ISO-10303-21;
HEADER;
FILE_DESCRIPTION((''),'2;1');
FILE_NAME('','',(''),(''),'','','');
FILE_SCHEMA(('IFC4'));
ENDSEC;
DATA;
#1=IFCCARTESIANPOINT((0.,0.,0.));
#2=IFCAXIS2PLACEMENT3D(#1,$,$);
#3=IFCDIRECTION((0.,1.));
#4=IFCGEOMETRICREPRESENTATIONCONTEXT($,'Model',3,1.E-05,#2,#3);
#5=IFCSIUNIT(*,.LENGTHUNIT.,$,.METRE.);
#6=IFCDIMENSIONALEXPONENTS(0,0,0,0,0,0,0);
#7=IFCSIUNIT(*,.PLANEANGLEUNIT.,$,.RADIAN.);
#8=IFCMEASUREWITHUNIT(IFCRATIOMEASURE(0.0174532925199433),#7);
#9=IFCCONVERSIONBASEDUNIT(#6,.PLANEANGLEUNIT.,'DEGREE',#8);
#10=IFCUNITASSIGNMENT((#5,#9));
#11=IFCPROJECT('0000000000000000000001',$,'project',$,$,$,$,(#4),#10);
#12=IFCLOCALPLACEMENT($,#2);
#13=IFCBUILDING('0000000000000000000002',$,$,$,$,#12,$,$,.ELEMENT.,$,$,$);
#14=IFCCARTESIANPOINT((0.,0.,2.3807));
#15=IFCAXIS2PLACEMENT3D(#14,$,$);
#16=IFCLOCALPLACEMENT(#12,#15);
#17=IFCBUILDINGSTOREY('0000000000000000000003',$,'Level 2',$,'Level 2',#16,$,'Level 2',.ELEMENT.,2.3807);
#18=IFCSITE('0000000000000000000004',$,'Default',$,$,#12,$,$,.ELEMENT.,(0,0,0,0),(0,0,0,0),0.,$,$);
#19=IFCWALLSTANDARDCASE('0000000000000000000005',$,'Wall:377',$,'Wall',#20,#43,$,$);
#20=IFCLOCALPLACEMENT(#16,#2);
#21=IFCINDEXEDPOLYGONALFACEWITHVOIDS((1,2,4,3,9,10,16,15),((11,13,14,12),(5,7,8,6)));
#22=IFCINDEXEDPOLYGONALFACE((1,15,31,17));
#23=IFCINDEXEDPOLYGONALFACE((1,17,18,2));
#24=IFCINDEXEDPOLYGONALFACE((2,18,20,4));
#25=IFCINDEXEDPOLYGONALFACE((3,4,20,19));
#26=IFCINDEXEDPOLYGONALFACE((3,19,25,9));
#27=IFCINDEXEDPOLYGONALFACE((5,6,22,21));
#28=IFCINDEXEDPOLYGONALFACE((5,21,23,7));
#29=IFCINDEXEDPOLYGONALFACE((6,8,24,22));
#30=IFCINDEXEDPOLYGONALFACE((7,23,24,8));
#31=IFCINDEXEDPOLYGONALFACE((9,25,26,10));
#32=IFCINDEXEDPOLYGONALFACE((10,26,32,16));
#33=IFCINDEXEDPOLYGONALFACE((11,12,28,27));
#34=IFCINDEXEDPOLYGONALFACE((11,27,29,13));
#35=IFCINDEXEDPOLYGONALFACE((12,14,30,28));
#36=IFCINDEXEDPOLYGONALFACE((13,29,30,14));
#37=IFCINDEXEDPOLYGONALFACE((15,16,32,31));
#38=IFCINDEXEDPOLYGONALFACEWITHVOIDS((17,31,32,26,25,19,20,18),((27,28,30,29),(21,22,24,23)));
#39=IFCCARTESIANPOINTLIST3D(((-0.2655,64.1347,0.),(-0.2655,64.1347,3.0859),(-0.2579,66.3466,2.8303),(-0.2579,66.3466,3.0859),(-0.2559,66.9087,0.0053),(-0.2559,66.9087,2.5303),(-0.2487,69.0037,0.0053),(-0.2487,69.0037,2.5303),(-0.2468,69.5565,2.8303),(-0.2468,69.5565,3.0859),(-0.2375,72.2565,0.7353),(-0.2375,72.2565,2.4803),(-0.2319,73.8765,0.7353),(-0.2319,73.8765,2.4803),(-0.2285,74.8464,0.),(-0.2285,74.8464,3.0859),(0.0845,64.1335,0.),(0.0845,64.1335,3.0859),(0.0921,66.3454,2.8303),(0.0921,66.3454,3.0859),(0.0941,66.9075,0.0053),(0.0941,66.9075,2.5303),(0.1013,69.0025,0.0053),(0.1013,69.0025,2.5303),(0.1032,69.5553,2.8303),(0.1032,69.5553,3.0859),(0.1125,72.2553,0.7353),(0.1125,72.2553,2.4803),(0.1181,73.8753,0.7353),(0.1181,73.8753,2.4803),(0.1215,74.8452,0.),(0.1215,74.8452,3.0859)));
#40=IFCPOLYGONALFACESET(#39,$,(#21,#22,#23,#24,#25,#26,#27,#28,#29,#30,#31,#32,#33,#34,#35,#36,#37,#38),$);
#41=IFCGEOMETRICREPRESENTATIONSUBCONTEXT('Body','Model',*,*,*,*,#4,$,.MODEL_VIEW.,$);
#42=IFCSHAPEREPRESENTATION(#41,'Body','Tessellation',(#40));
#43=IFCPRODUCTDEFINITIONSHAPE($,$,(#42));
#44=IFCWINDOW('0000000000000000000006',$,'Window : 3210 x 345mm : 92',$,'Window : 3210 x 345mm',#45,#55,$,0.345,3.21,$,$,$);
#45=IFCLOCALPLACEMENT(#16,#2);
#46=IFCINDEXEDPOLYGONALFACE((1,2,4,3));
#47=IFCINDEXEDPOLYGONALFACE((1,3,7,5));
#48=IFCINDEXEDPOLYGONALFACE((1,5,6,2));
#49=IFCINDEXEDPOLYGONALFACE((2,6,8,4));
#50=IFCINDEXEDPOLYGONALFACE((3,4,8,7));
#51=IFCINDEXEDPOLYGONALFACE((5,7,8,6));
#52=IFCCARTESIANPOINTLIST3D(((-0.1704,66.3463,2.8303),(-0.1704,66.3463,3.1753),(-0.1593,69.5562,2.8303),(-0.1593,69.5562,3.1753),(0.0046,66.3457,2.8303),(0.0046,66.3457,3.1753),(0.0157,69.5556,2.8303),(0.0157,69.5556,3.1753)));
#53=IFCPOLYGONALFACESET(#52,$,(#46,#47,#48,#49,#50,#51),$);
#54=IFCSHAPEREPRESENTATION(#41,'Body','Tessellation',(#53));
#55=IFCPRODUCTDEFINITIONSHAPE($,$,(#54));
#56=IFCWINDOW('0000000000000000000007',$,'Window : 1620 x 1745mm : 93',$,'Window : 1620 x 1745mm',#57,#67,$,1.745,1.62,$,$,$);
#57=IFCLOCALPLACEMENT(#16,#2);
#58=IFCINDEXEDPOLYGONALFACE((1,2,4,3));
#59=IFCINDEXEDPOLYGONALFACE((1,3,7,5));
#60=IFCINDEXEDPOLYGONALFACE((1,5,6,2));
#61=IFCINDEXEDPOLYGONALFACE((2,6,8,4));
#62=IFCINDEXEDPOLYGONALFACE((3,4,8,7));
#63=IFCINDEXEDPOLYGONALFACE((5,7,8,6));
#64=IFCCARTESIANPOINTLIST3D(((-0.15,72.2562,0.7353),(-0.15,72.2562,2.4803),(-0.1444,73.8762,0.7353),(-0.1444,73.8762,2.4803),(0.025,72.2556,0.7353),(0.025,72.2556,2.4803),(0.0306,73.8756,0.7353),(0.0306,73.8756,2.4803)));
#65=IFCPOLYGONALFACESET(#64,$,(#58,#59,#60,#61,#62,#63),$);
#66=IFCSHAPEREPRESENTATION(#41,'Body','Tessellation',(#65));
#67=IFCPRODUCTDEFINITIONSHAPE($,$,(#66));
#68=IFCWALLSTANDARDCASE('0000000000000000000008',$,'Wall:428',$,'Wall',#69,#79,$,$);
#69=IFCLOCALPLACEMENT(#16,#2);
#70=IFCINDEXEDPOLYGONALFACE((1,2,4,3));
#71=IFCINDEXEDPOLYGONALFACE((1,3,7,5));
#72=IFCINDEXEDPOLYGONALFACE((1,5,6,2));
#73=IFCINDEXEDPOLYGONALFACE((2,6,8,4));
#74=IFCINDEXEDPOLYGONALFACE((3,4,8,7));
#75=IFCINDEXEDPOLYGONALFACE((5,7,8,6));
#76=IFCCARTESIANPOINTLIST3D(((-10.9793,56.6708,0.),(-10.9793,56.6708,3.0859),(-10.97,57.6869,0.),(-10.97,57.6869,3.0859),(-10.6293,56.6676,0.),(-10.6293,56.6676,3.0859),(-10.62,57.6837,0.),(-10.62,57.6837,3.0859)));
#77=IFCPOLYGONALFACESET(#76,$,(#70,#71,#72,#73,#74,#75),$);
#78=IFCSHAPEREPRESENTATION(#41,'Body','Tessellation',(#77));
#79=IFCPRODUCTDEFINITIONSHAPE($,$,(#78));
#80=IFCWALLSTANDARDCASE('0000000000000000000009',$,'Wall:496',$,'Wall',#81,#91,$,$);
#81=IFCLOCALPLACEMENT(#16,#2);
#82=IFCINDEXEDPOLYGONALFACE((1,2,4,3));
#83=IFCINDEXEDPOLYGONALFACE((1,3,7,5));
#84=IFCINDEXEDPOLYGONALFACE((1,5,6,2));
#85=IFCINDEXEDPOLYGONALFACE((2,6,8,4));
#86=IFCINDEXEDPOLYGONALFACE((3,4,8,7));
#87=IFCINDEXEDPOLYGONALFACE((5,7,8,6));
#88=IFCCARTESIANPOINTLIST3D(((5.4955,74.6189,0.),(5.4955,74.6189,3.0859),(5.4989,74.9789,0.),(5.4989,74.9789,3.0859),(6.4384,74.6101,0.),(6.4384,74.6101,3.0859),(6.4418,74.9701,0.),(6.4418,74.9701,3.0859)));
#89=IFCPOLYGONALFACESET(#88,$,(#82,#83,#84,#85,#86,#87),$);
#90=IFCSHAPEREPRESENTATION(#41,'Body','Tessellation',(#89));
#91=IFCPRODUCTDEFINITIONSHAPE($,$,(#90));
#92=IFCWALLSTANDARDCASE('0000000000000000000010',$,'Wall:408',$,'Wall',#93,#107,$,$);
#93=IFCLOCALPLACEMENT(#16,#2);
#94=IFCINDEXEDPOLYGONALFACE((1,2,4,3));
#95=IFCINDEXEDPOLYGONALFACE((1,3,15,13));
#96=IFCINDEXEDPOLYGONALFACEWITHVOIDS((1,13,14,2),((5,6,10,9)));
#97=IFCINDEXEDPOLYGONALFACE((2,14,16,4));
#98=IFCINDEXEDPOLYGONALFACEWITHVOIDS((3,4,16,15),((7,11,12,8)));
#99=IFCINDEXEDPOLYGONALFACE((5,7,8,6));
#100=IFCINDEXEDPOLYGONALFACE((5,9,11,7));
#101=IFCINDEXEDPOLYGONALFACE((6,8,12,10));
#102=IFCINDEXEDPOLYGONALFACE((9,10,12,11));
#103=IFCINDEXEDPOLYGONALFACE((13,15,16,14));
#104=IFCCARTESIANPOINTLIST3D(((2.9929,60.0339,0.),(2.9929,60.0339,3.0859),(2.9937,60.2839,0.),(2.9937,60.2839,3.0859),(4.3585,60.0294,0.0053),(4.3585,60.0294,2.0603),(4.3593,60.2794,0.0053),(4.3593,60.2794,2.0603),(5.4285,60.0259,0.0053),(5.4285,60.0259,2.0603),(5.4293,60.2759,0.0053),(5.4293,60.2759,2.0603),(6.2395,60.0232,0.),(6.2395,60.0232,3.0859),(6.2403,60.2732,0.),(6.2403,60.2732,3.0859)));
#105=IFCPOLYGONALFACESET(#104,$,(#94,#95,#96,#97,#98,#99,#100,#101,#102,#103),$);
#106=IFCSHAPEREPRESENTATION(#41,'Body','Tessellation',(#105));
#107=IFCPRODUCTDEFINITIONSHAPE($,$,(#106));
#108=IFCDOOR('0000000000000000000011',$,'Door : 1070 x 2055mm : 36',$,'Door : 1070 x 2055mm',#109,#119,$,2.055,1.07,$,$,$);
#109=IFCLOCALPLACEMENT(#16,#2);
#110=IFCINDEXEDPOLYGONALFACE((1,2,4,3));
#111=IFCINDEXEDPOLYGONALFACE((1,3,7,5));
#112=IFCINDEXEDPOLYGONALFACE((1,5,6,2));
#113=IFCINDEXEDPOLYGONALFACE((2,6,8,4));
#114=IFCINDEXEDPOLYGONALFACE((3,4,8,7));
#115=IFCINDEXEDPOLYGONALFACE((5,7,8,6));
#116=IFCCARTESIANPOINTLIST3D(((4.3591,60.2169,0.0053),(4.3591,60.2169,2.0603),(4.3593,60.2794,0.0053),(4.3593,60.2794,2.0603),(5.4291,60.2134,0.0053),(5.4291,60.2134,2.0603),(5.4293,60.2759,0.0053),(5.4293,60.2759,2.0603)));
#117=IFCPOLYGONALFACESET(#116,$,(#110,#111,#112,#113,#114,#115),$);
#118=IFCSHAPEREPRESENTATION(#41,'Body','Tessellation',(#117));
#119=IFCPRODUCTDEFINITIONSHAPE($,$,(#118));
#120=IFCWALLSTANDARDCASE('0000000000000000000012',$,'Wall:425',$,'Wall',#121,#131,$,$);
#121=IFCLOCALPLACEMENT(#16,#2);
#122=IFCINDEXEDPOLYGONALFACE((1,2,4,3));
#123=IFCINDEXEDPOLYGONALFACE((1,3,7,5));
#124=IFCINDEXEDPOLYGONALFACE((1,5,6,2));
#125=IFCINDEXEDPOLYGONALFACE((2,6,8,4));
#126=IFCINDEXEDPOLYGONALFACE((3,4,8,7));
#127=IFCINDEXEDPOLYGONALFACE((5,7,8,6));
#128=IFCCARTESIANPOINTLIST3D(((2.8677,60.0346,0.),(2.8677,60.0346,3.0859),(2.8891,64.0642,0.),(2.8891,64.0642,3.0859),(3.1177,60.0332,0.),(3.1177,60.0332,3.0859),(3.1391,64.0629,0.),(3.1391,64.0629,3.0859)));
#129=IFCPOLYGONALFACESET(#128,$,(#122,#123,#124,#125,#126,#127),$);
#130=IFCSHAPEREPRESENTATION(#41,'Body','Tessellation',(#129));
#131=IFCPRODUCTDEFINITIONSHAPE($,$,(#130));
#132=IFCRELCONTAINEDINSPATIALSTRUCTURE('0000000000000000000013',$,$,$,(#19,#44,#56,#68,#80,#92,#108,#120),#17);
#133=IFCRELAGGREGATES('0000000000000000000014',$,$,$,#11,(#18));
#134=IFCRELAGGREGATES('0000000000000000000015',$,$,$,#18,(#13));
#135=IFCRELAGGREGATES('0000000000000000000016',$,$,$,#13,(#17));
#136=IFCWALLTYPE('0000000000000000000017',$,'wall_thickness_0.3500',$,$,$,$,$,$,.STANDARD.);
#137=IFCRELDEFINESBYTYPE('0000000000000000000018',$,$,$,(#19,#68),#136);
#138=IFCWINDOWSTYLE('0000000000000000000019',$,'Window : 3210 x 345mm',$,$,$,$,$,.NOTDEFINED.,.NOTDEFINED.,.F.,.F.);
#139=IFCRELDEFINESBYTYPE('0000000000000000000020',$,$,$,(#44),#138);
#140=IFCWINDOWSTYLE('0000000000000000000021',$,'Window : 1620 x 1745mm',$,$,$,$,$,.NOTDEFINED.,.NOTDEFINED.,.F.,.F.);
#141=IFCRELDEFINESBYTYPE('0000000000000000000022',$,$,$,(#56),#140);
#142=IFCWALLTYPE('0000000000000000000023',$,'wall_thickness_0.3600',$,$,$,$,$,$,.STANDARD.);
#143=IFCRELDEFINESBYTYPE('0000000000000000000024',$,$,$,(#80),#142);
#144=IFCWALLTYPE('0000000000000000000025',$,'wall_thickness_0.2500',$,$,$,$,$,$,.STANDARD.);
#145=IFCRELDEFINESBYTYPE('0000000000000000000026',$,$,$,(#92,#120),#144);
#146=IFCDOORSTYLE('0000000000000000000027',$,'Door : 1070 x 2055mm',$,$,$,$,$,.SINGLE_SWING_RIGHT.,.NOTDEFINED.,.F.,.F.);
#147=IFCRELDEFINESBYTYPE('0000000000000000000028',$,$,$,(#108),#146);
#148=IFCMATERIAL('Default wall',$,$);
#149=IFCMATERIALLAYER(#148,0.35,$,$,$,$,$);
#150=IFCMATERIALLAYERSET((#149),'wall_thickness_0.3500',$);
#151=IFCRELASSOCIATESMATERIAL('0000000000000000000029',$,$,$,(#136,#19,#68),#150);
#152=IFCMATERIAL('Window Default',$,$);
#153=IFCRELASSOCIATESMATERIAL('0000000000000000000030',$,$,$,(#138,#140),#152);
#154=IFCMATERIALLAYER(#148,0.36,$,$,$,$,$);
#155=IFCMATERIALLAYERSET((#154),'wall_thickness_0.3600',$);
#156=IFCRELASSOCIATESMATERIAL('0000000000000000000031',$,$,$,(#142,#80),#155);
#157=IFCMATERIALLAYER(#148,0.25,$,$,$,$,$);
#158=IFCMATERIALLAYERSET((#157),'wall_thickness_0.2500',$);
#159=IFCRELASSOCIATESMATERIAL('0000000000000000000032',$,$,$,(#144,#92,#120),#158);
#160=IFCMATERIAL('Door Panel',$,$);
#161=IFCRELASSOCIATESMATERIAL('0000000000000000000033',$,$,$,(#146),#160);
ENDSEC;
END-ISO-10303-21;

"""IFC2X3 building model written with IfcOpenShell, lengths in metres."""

from ifc_helpers import new_model, entity, si_unit, converted_unit, direction, frame, frame_2d, origin, origin_2d_with_axis, place, context, subcontext, project, spatial, polyline, rectangle, outline, extrude, source, transform, mapped, material, layer, layer_set, layer_usage, type_object, type_shapes, element, fill, save


model = new_model("IFC2X3")

# Units and contexts
model_context = context("Model", 3, precision=1e-05, world=origin(), true_north=direction((0.0, 1.0)))
body_context = subcontext(model_context, "Body", "Model", "MODEL_VIEW")
ifc_project = project(units=[si_unit("LENGTHUNIT", "METRE"), converted_unit("PLANEANGLEUNIT", "DEGREE", entity("IfcRatioMeasure", 0.0174532925199433), si_unit("PLANEANGLEUNIT", "RADIAN"), dimensions=[0, 0, 0, 0, 0, 0, 0])], contexts=[model_context])

# Site, building, storey
placement_1 = place(None, origin())
site = spatial("IfcSite", under=ifc_project, at=placement_1, Name="Default", CompositionType="ELEMENT", RefLatitude=(0, 0, 0, 0), RefLongitude=(0, 0, 0, 0), RefElevation=0.0)
building = spatial("IfcBuilding", under=site, at=placement_1, CompositionType="ELEMENT")
storey_placement = place(placement_1, frame((0.0, 0.0, 2.3807)))
storey = spatial("IfcBuildingStorey", under=building, at=storey_placement, Name="Level 2", ObjectType="Level 2", LongName="Level 2", CompositionType="ELEMENT", Elevation=2.3807)

# Wall, openings, windows
ifc_material_1 = material(Name="Default wall")
ifc_layer_1 = layer(ifc_material_1, 0.35)
ifc_layer_set_1 = layer_set([ifc_layer_1], Name="wall_thickness_0.3500")
ifc_layer_usage_1 = layer_usage(ifc_layer_set_1, "AXIS2", "POSITIVE", -0.175)
wall_type_1 = type_object("IfcWallType", Name="wall_thickness_0.3500", PredefinedType="STANDARD", material=ifc_layer_set_1)
wall_1_placement = place(storey_placement, frame((-0.0535, 74.8458, 0.0), z_axis=(0.0, 0.0, 1.0), x_axis=(-0.003454, -0.999994, 0.0)))
wall_1 = element("IfcWallStandardCase", 1, at=wall_1_placement, inside=storey, type_object=wall_type_1, material=ifc_layer_usage_1, Name="Wall:377", ObjectType="Wall", context=body_context, shape_type="SweptSolid", body=[
    extrude(outline(polyline([(10.7117, -0.175), (10.7117, 0.175), (0.0, 0.175), (0.0, -0.175), (10.7117, -0.175)])), origin(), (0.0, 0.0, 1.0), 3.0859),
])
opening_1_placement = place(wall_1_placement, frame((5.8427, -0.175, 0.0053)))
element("IfcOpeningElement", 2, at=opening_1_placement, cuts=wall_1, ObjectType="Opening", context=body_context, shape_type="SweptSolid", body=[
    extrude(rectangle(XDim=2.095, YDim=2.525, at=frame_2d((1.2625, 1.0475), x_axis=(0.0, 1.0))), frame((0.0, 0.0, 0.0), z_axis=(0.0, 1.0, 0.0), x_axis=(0.0, 0.0, 1.0)), (0.0, 0.0, 1.0), 0.35),
])
opening_2_placement = place(wall_1_placement, frame((5.2899, -0.175, 2.8303)))
opening_2 = element("IfcOpeningElement", 3, at=opening_2_placement, cuts=wall_1, ObjectType="Opening", context=body_context, shape_type="SweptSolid", body=[
    extrude(rectangle(XDim=3.21, YDim=0.345, at=frame_2d((0.1725, 1.605), x_axis=(0.0, 1.0))), frame((0.0, 0.0, 0.0), z_axis=(0.0, 1.0, 0.0), x_axis=(0.0, 0.0, 1.0)), (0.0, 0.0, 1.0), 0.35),
])
opening_3_placement = place(wall_1_placement, frame((0.9699, -0.175, 0.7353)))
opening_3 = element("IfcOpeningElement", 4, at=opening_3_placement, cuts=wall_1, ObjectType="Opening", context=body_context, shape_type="SweptSolid", body=[
    extrude(rectangle(XDim=1.62, YDim=1.745, at=frame_2d((0.8725, 0.81), x_axis=(0.0, 1.0))), frame((0.0, 0.0, 0.0), z_axis=(0.0, 1.0, 0.0), x_axis=(0.0, 0.0, 1.0)), (0.0, 0.0, 1.0), 0.35),
])
ifc_material_2 = material(Name="Window Default")
window_style_1 = type_object("IfcWindowStyle", Name="Window : 3210 x 345mm", ConstructionType="NOTDEFINED", OperationType="NOTDEFINED", ParameterTakesPrecedence=False, Sizeable=False, material=ifc_material_2)
shared_shape_1 = source(origin(), body_context, "Body", "SweptSolid", [
    extrude(rectangle(XDim=0.175, YDim=3.21, at=origin_2d_with_axis()), frame((1.605, 0.175, 0.0), z_axis=(0.0, 0.0, 1.0), x_axis=(0.0, 1.0, 0.0)), (0.0, 0.0, 1.0), 0.345),
])
type_shapes(window_style_1, [shared_shape_1])
window_1_placement = place(opening_2_placement, origin())
window_1 = element("IfcWindow", 5, at=window_1_placement, inside=storey, type_object=window_style_1, Name="Window : 3210 x 345mm : 92", ObjectType="Window : 3210 x 345mm", OverallHeight=0.345, OverallWidth=3.21, context=body_context, shape_type="MappedRepresentation", body=[
    mapped(shared_shape_1, transform((0.0, 0.0, 0.0), scale=1.0)),
])
fill(opening_2, window_1)
window_style_2 = type_object("IfcWindowStyle", Name="Window : 1620 x 1745mm", ConstructionType="NOTDEFINED", OperationType="NOTDEFINED", ParameterTakesPrecedence=False, Sizeable=False, material=ifc_material_2)
shared_shape_2 = source(origin(), body_context, "Body", "SweptSolid", [
    extrude(rectangle(XDim=0.175, YDim=1.62, at=origin_2d_with_axis()), frame((0.81, 0.175, 0.0), z_axis=(0.0, 0.0, 1.0), x_axis=(0.0, 1.0, 0.0)), (0.0, 0.0, 1.0), 1.745),
])
type_shapes(window_style_2, [shared_shape_2])
window_2_placement = place(opening_3_placement, origin())
window_2 = element("IfcWindow", 6, at=window_2_placement, inside=storey, type_object=window_style_2, Name="Window : 1620 x 1745mm : 93", ObjectType="Window : 1620 x 1745mm", OverallHeight=1.745, OverallWidth=1.62, context=body_context, shape_type="MappedRepresentation", body=[
    mapped(shared_shape_2, transform((0.0, 0.0, 0.0), scale=1.0)),
])
fill(opening_3, window_2)

# Walls
wall_2_placement = place(storey_placement, frame((-10.795, 57.6853, 0.0), z_axis=(0.0, 0.0, 1.0), x_axis=(-0.009106, -0.999959, 0.0)))
element("IfcWallStandardCase", 7, at=wall_2_placement, inside=storey, type_object=wall_type_1, material=ifc_layer_usage_1, Name="Wall:428", ObjectType="Wall", context=body_context, shape_type="SweptSolid", body=[
    extrude(outline(polyline([(1.0161, -0.175), (1.0161, 0.175), (0.0, 0.175), (0.0, -0.175), (1.0161, -0.175)])), origin(), (0.0, 0.0, 1.0), 3.0859),
])
ifc_layer_2 = layer(ifc_material_1, 0.36)
ifc_layer_set_2 = layer_set([ifc_layer_2], Name="wall_thickness_0.3600")
ifc_layer_usage_2 = layer_usage(ifc_layer_set_2, "AXIS2", "POSITIVE", -0.18)
wall_type_2 = type_object("IfcWallType", Name="wall_thickness_0.3600", PredefinedType="STANDARD", material=ifc_layer_set_2)
wall_3_placement = place(storey_placement, frame((5.4972, 74.7989, 0.0), z_axis=(0.0, 0.0, 1.0), x_axis=(0.999956, -0.009346, 0.0)))
element("IfcWallStandardCase", 8, at=wall_3_placement, inside=storey, type_object=wall_type_2, material=ifc_layer_usage_2, Name="Wall:496", ObjectType="Wall", context=body_context, shape_type="SweptSolid", body=[
    extrude(outline(polyline([(0.9429, -0.18), (0.9429, 0.18), (0.0, 0.18), (0.0, -0.18), (0.9429, -0.18)])), origin(), (0.0, 0.0, 1.0), 3.0859),
])

# Wall, opening, door
ifc_layer_3 = layer(ifc_material_1, 0.25)
ifc_layer_set_3 = layer_set([ifc_layer_3], Name="wall_thickness_0.2500")
ifc_layer_usage_3 = layer_usage(ifc_layer_set_3, "AXIS2", "POSITIVE", -0.125)
wall_type_3 = type_object("IfcWallType", Name="wall_thickness_0.2500", PredefinedType="STANDARD", material=ifc_layer_set_3)
wall_4_placement = place(storey_placement, frame((2.9933, 60.1589, 0.0), z_axis=(0.0, 0.0, 1.0), x_axis=(0.999995, -0.003299, 0.0)))
wall_4 = element("IfcWallStandardCase", 9, at=wall_4_placement, inside=storey, type_object=wall_type_3, material=ifc_layer_usage_3, Name="Wall:408", ObjectType="Wall", context=body_context, shape_type="SweptSolid", body=[
    extrude(outline(polyline([(3.2466, -0.125), (3.2466, 0.125), (0.0, 0.125), (0.0, -0.125), (3.2466, -0.125)])), origin(), (0.0, 0.0, 1.0), 3.0859),
])
opening_4_placement = place(wall_4_placement, frame((1.3656, -0.125, 0.0053)))
opening_4 = element("IfcOpeningElement", 10, at=opening_4_placement, cuts=wall_4, ObjectType="Opening", context=body_context, shape_type="SweptSolid", body=[
    extrude(rectangle(XDim=1.07, YDim=2.055, at=frame_2d((1.0275, 0.535), x_axis=(0.0, 1.0))), frame((0.0, 0.0, 0.0), z_axis=(0.0, 1.0, 0.0), x_axis=(0.0, 0.0, 1.0)), (0.0, 0.0, 1.0), 0.25),
])
ifc_material_3 = material(Name="Door Panel")
door_style_1 = type_object("IfcDoorStyle", Name="Door : 1070 x 2055mm", ConstructionType="NOTDEFINED", OperationType="SINGLE_SWING_RIGHT", ParameterTakesPrecedence=False, Sizeable=False, material=ifc_material_3)
shared_shape_3 = source(origin(), body_context, "Body", "SweptSolid", [
    extrude(rectangle(XDim=0.0625, YDim=1.07, at=origin_2d_with_axis()), frame((0.535, 0.2188, 0.0), z_axis=(0.0, 0.0, 1.0), x_axis=(0.0, 1.0, 0.0)), (0.0, 0.0, 1.0), 2.055),
])
type_shapes(door_style_1, [shared_shape_3])
door_1_placement = place(opening_4_placement, origin())
door_1 = element("IfcDoor", 11, at=door_1_placement, inside=storey, type_object=door_style_1, Name="Door : 1070 x 2055mm : 36", ObjectType="Door : 1070 x 2055mm", OverallHeight=2.055, OverallWidth=1.07, context=body_context, shape_type="MappedRepresentation", body=[
    mapped(shared_shape_3, transform((0.0, 0.0, 0.0), scale=1.0)),
])
fill(opening_4, door_1)

# Wall
wall_5_placement = place(storey_placement, frame((3.0141, 64.0636, 0.0), z_axis=(0.0, 0.0, 1.0), x_axis=(-0.005312, -0.999986, 0.0)))
element("IfcWallStandardCase", 12, at=wall_5_placement, inside=storey, type_object=wall_type_3, material=ifc_layer_usage_3, Name="Wall:425", ObjectType="Wall", context=body_context, shape_type="SweptSolid", body=[
    extrude(outline(polyline([(4.0297, -0.125), (4.0297, 0.125), (0.0, 0.125), (0.0, -0.125), (4.0297, -0.125)])), origin(), (0.0, 0.0, 1.0), 3.0859),
])

save(model, "model.ifc")
